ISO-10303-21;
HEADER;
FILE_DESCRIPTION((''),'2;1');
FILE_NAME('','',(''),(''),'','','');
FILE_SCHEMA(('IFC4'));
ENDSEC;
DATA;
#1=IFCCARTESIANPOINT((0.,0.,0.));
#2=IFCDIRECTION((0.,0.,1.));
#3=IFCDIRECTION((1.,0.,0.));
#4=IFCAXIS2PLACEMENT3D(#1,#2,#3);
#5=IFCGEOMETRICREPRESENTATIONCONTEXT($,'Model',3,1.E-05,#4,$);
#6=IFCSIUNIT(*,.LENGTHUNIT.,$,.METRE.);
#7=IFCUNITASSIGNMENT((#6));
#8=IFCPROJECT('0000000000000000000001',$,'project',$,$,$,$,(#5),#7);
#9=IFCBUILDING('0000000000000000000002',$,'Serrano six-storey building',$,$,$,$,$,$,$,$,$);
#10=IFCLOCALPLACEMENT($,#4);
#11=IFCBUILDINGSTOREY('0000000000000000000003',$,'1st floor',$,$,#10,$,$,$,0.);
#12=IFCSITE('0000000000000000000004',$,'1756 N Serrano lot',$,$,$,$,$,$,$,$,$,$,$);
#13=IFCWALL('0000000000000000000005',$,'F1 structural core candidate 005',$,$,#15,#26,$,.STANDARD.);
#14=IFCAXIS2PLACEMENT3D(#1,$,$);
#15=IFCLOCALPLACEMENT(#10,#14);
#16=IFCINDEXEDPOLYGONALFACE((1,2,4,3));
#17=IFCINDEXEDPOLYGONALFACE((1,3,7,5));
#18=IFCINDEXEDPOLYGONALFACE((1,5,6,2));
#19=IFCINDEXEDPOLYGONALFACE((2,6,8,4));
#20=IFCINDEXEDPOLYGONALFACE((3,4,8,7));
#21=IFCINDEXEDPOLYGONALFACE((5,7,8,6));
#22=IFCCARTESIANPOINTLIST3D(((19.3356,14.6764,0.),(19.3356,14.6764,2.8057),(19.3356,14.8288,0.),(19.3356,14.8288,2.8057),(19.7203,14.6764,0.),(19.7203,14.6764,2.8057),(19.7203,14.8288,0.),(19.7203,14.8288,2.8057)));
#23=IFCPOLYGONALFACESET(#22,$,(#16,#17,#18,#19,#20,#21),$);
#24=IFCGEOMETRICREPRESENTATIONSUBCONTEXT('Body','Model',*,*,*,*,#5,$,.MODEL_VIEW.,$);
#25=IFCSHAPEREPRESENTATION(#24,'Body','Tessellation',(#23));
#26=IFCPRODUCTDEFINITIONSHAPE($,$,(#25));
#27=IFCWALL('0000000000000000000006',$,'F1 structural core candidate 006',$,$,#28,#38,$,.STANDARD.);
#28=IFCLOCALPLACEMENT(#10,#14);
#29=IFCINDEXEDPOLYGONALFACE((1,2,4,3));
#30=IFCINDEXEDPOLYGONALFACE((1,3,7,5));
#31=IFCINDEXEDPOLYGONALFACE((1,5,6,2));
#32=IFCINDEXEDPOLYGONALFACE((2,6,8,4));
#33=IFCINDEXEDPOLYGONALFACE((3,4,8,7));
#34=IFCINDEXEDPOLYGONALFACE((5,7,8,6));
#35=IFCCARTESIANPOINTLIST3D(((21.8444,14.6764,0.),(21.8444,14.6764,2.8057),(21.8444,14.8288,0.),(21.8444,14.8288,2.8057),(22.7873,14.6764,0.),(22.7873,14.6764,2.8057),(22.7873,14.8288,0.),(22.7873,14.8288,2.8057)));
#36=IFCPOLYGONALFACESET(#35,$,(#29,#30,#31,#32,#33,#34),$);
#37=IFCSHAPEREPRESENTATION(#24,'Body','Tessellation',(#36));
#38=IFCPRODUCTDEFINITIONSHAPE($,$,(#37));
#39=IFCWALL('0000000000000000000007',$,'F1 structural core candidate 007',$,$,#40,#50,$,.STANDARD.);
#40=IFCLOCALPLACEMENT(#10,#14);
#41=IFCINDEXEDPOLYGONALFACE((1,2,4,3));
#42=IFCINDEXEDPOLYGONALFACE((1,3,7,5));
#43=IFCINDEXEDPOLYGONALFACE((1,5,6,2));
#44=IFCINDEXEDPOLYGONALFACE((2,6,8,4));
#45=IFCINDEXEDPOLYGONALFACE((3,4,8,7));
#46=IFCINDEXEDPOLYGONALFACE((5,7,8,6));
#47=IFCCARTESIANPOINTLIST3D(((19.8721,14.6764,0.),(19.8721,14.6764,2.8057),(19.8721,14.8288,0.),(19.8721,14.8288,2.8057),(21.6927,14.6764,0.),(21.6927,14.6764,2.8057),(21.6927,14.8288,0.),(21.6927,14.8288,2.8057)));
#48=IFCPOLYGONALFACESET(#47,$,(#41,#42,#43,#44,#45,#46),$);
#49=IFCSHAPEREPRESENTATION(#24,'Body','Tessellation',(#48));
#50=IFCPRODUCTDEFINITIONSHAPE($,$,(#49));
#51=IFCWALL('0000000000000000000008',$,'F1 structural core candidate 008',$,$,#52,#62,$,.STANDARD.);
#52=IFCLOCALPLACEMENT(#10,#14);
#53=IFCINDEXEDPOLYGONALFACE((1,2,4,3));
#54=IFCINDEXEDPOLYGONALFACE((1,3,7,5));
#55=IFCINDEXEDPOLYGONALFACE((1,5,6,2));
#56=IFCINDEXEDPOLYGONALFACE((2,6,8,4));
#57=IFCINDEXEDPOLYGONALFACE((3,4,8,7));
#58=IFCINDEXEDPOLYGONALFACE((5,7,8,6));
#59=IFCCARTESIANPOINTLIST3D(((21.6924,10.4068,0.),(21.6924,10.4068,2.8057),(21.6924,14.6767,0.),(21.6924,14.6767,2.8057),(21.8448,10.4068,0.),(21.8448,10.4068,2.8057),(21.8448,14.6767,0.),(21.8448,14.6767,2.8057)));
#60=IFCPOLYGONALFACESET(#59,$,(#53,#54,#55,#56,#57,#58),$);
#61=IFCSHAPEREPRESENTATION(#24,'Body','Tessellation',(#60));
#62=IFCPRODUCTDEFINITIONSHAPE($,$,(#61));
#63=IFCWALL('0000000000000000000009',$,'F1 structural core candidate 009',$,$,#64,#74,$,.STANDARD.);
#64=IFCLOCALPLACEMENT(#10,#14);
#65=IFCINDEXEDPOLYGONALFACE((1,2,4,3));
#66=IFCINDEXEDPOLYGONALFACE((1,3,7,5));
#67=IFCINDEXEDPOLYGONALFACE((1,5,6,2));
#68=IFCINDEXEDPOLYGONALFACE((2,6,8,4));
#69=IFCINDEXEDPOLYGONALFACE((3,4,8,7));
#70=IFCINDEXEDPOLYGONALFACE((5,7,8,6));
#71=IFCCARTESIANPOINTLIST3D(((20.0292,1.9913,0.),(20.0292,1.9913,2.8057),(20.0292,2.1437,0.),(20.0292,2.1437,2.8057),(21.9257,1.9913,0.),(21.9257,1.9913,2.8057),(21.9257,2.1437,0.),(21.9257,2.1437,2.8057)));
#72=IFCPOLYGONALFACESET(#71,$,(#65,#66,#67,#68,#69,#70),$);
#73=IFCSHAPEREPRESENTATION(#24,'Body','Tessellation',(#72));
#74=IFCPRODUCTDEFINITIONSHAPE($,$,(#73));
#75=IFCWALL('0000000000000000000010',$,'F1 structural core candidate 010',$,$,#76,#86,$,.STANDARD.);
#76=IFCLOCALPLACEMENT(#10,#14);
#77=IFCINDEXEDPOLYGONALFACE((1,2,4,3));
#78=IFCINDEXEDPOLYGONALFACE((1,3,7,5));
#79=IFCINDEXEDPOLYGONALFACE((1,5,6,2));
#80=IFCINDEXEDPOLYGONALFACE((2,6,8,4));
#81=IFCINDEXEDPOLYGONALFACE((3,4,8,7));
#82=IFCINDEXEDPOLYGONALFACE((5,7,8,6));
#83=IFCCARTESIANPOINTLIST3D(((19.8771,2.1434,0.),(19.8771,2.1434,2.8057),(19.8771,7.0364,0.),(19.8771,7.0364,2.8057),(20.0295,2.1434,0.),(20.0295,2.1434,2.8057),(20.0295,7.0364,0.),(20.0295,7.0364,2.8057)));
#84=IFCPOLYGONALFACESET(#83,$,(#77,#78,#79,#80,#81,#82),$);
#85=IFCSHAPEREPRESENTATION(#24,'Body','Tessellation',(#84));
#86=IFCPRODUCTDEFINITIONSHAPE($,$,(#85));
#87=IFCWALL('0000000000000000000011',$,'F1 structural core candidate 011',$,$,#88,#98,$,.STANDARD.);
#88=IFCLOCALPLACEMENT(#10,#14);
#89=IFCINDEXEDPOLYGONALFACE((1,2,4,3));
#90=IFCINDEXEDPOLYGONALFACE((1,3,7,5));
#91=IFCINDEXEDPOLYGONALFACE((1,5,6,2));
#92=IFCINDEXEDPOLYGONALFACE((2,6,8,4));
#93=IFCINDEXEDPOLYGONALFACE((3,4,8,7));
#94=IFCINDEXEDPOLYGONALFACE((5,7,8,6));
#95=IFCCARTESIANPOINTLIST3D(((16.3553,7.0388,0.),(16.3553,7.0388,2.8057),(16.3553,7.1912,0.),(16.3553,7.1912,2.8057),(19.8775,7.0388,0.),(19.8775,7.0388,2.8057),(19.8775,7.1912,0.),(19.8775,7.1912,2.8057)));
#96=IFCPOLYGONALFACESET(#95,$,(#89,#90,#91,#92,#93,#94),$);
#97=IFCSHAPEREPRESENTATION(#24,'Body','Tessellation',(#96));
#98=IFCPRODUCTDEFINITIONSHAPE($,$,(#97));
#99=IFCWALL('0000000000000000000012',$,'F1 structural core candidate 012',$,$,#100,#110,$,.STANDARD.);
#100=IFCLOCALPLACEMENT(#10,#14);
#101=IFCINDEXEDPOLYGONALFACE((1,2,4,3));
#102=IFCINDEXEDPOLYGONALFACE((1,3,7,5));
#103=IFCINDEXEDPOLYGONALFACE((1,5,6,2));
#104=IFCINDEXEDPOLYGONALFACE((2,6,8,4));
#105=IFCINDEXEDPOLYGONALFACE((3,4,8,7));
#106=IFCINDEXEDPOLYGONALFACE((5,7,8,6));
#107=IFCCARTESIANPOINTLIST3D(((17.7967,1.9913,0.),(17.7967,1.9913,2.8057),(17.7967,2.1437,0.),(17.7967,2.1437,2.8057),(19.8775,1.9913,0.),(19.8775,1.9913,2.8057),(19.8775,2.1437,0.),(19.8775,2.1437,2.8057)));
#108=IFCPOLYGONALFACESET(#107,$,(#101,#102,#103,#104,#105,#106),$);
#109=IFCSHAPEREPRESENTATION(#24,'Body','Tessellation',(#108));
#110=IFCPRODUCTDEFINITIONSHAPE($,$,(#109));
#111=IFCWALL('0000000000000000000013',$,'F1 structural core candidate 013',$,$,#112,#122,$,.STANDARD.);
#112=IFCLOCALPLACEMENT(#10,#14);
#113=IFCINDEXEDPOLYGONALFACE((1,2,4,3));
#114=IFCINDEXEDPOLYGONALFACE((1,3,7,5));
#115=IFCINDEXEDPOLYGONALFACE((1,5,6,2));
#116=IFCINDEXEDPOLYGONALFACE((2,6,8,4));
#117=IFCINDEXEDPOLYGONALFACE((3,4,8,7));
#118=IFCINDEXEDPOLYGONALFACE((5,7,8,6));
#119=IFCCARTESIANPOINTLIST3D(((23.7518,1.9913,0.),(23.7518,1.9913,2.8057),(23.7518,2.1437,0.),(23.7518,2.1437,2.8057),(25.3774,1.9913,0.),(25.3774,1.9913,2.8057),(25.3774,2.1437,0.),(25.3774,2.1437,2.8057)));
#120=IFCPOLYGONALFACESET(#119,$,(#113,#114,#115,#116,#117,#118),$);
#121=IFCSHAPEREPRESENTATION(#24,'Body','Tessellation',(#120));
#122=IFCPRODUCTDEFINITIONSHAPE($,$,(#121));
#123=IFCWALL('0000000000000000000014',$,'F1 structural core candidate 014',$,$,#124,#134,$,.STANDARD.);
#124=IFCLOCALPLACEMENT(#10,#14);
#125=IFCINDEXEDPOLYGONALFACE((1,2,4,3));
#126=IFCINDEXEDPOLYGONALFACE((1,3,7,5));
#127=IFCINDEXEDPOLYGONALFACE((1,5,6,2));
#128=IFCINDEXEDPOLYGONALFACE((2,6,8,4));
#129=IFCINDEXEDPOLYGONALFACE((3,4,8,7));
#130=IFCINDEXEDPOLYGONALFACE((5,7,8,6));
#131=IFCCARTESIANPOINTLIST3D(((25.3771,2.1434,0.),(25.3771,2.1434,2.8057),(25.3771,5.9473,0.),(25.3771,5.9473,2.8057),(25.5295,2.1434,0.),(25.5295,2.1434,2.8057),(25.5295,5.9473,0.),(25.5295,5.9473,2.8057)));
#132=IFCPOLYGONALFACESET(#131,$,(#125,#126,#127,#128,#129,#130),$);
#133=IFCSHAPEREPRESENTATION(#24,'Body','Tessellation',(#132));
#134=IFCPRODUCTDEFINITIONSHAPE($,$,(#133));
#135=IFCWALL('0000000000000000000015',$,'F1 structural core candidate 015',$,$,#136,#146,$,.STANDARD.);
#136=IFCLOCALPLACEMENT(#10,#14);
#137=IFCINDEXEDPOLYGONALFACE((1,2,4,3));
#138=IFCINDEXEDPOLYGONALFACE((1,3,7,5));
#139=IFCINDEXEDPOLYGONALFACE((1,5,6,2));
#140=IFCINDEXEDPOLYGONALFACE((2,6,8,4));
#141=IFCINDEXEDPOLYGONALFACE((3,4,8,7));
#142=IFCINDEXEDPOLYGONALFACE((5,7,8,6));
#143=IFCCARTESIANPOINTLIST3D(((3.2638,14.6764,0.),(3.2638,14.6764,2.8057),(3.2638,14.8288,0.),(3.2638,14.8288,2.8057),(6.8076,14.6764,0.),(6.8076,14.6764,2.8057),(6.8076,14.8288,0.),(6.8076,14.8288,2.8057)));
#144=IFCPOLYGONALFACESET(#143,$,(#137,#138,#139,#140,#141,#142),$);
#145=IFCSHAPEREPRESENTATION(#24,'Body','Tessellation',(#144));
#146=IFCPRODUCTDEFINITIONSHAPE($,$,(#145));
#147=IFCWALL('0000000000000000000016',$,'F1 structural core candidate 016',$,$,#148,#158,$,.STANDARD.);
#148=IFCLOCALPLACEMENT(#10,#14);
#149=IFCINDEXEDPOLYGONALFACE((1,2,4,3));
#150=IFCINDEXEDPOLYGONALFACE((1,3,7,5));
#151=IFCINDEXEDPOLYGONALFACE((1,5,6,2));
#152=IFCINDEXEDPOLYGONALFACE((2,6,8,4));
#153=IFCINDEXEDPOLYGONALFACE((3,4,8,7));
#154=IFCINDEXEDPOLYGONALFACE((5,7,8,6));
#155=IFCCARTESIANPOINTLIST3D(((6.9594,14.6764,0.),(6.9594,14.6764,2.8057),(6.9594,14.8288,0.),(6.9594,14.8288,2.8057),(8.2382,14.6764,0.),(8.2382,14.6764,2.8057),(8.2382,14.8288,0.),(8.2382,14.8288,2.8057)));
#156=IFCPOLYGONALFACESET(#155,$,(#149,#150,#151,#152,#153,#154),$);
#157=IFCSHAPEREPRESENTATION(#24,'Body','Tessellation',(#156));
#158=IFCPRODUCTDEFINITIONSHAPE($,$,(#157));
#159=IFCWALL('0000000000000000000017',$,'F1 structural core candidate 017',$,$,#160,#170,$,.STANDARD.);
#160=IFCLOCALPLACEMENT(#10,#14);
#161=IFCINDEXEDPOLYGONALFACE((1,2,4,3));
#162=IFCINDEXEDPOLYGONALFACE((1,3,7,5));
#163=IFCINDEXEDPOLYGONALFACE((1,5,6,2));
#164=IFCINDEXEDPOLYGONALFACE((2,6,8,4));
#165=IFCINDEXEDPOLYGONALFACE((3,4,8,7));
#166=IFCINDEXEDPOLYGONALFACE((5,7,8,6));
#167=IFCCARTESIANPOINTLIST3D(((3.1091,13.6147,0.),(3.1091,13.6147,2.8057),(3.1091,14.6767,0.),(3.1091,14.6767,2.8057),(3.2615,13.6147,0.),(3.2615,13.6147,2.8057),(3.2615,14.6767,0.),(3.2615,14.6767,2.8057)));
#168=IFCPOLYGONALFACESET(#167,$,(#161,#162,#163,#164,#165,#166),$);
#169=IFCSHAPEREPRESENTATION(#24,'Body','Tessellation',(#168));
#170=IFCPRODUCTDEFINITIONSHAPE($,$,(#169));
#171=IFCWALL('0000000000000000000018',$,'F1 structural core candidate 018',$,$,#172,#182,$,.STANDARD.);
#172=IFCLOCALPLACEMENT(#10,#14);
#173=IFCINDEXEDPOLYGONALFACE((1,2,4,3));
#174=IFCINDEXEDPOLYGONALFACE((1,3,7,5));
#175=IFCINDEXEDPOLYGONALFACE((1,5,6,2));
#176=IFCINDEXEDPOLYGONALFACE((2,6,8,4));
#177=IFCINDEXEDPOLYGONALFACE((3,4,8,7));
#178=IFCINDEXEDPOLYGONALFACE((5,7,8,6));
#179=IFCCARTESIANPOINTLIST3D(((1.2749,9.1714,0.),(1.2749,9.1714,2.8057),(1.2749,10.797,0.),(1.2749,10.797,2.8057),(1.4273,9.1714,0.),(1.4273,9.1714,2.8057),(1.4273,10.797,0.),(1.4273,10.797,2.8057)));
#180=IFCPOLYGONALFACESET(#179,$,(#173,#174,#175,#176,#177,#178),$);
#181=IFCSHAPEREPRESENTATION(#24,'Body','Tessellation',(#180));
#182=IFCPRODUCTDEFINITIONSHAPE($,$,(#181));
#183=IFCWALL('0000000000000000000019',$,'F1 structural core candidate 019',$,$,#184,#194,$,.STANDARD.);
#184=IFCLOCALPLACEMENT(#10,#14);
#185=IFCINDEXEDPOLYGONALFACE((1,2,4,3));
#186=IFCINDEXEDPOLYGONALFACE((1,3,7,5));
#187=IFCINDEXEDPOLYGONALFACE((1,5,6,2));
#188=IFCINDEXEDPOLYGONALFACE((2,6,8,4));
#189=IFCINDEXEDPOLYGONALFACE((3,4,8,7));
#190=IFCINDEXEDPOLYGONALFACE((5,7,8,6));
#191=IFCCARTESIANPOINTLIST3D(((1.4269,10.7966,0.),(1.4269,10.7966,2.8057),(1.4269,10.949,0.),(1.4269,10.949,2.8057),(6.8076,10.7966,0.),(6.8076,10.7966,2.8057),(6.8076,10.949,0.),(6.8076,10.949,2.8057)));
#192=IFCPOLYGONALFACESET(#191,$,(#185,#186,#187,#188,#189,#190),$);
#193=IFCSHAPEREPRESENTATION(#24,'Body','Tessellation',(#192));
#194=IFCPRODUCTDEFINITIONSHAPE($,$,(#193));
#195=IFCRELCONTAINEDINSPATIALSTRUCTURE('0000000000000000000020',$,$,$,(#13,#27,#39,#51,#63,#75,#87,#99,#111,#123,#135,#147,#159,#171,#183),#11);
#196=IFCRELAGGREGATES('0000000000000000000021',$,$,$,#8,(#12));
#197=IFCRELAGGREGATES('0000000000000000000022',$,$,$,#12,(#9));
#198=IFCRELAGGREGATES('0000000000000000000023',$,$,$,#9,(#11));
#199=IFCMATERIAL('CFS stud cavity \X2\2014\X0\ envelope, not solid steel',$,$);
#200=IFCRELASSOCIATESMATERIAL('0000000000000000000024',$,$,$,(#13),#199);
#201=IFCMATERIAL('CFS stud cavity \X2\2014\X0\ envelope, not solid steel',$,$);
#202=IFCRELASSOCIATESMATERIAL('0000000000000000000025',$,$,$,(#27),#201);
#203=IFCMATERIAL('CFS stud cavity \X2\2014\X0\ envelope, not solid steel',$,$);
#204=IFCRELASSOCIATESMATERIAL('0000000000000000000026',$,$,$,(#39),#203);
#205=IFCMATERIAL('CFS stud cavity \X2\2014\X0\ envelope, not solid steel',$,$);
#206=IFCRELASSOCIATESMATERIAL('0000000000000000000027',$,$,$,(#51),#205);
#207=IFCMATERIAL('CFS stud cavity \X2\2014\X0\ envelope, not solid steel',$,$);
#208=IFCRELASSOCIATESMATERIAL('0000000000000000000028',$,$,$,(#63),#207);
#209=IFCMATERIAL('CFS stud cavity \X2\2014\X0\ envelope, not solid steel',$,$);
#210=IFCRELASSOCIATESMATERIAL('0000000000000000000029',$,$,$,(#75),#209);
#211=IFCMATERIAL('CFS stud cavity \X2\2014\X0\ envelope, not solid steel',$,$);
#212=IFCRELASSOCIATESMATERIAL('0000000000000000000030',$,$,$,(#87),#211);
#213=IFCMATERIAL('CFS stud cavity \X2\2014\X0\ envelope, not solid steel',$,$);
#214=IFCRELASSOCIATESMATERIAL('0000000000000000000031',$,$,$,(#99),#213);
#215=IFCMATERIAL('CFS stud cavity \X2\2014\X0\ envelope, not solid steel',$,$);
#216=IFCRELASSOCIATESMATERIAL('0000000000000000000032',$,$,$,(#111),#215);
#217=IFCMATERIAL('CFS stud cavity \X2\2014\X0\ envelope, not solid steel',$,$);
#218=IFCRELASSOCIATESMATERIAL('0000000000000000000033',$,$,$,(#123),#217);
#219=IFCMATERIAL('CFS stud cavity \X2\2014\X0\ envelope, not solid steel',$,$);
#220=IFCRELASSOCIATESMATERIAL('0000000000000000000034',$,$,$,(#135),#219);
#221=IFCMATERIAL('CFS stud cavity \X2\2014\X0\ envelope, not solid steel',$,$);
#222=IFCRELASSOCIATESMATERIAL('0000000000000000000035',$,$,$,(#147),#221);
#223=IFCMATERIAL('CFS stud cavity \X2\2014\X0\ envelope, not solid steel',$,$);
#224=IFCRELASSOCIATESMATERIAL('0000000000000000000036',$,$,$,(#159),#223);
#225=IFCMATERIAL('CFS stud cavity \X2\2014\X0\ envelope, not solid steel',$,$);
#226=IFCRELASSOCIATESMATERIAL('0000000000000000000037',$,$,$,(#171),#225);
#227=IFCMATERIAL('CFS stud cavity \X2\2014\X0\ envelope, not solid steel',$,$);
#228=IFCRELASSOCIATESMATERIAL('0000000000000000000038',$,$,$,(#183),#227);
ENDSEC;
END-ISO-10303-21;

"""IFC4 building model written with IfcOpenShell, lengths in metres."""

from ifc_helpers import new_model, si_unit, origin, origin_with_axes, place, context, subcontext, project, spatial, polyline, outline, extrude, material, element, save


model = new_model("IFC4")

# Units and contexts
model_context = context("Model", 3, precision=1e-05, world=origin_with_axes())
body_context = subcontext(model_context, "Body", "Model", "MODEL_VIEW")
ifc_project = project(units=[si_unit("LENGTHUNIT", "METRE")], contexts=[model_context])

# Site, building, storey
site = spatial("IfcSite", under=ifc_project, Name="1756 N Serrano lot")
building = spatial("IfcBuilding", under=site, Name="Serrano six-storey building")
storey_placement = place(None, origin_with_axes())
storey = spatial("IfcBuildingStorey", under=building, at=storey_placement, Name="1st floor", Elevation=0.0)

# Walls
ifc_material_1 = material(Name="CFS stud cavity — envelope, not solid steel")
wall_1_placement = place(storey_placement, origin_with_axes())
element("IfcWall", 1, at=wall_1_placement, inside=storey, material=ifc_material_1, Name="F1 structural core candidate 005", PredefinedType="STANDARD", context=body_context, shape_type="SweptSolid", body=[
    extrude(outline(polyline([(19.7203, 14.8288), (19.7203, 14.6764), (19.3356, 14.6764), (19.3356, 14.8288), (19.7203, 14.8288)])), origin(), (0.0, 0.0, 1.0), 2.8057),
])
ifc_material_2 = material(Name="CFS stud cavity — envelope, not solid steel")
wall_2_placement = place(storey_placement, origin_with_axes())
element("IfcWall", 2, at=wall_2_placement, inside=storey, material=ifc_material_2, Name="F1 structural core candidate 006", PredefinedType="STANDARD", context=body_context, shape_type="SweptSolid", body=[
    extrude(outline(polyline([(22.7873, 14.8288), (22.7873, 14.6764), (21.8444, 14.6764), (21.8444, 14.8288), (22.7873, 14.8288)])), origin(), (0.0, 0.0, 1.0), 2.8057),
])
ifc_material_3 = material(Name="CFS stud cavity — envelope, not solid steel")
wall_3_placement = place(storey_placement, origin_with_axes())
element("IfcWall", 3, at=wall_3_placement, inside=storey, material=ifc_material_3, Name="F1 structural core candidate 007", PredefinedType="STANDARD", context=body_context, shape_type="SweptSolid", body=[
    extrude(outline(polyline([(21.6927, 14.8288), (21.6927, 14.6764), (19.8721, 14.6764), (19.8721, 14.8288), (21.6927, 14.8288)])), origin(), (0.0, 0.0, 1.0), 2.8057),
])
ifc_material_4 = material(Name="CFS stud cavity — envelope, not solid steel")
wall_4_placement = place(storey_placement, origin_with_axes())
element("IfcWall", 4, at=wall_4_placement, inside=storey, material=ifc_material_4, Name="F1 structural core candidate 008", PredefinedType="STANDARD", context=body_context, shape_type="SweptSolid", body=[
    extrude(outline(polyline([(21.8448, 10.4068), (21.6924, 10.4068), (21.6924, 14.6767), (21.8448, 14.6767), (21.8448, 10.4068)])), origin(), (0.0, 0.0, 1.0), 2.8057),
])
ifc_material_5 = material(Name="CFS stud cavity — envelope, not solid steel")
wall_5_placement = place(storey_placement, origin_with_axes())
element("IfcWall", 5, at=wall_5_placement, inside=storey, material=ifc_material_5, Name="F1 structural core candidate 009", PredefinedType="STANDARD", context=body_context, shape_type="SweptSolid", body=[
    extrude(outline(polyline([(21.9257, 2.1437), (21.9257, 1.9913), (20.0292, 1.9913), (20.0292, 2.1437), (21.9257, 2.1437)])), origin(), (0.0, 0.0, 1.0), 2.8057),
])
ifc_material_6 = material(Name="CFS stud cavity — envelope, not solid steel")
wall_6_placement = place(storey_placement, origin_with_axes())
element("IfcWall", 6, at=wall_6_placement, inside=storey, material=ifc_material_6, Name="F1 structural core candidate 010", PredefinedType="STANDARD", context=body_context, shape_type="SweptSolid", body=[
    extrude(outline(polyline([(20.0295, 2.1434), (19.8771, 2.1434), (19.8771, 7.0364), (20.0295, 7.0364), (20.0295, 2.1434)])), origin(), (0.0, 0.0, 1.0), 2.8057),
])
ifc_material_7 = material(Name="CFS stud cavity — envelope, not solid steel")
wall_7_placement = place(storey_placement, origin_with_axes())
element("IfcWall", 7, at=wall_7_placement, inside=storey, material=ifc_material_7, Name="F1 structural core candidate 011", PredefinedType="STANDARD", context=body_context, shape_type="SweptSolid", body=[
    extrude(outline(polyline([(19.8775, 7.1912), (19.8775, 7.0388), (16.3553, 7.0388), (16.3553, 7.1912), (19.8775, 7.1912)])), origin(), (0.0, 0.0, 1.0), 2.8057),
])
ifc_material_8 = material(Name="CFS stud cavity — envelope, not solid steel")
wall_8_placement = place(storey_placement, origin_with_axes())
element("IfcWall", 8, at=wall_8_placement, inside=storey, material=ifc_material_8, Name="F1 structural core candidate 012", PredefinedType="STANDARD", context=body_context, shape_type="SweptSolid", body=[
    extrude(outline(polyline([(19.8775, 2.1437), (19.8775, 1.9913), (17.7967, 1.9913), (17.7967, 2.1437), (19.8775, 2.1437)])), origin(), (0.0, 0.0, 1.0), 2.8057),
])
ifc_material_9 = material(Name="CFS stud cavity — envelope, not solid steel")
wall_9_placement = place(storey_placement, origin_with_axes())
element("IfcWall", 9, at=wall_9_placement, inside=storey, material=ifc_material_9, Name="F1 structural core candidate 013", PredefinedType="STANDARD", context=body_context, shape_type="SweptSolid", body=[
    extrude(outline(polyline([(25.3774, 2.1437), (25.3774, 1.9913), (23.7518, 1.9913), (23.7518, 2.1437), (25.3774, 2.1437)])), origin(), (0.0, 0.0, 1.0), 2.8057),
])
ifc_material_10 = material(Name="CFS stud cavity — envelope, not solid steel")
wall_10_placement = place(storey_placement, origin_with_axes())
element("IfcWall", 10, at=wall_10_placement, inside=storey, material=ifc_material_10, Name="F1 structural core candidate 014", PredefinedType="STANDARD", context=body_context, shape_type="SweptSolid", body=[
    extrude(outline(polyline([(25.5295, 2.1434), (25.3771, 2.1434), (25.3771, 5.9473), (25.5295, 5.9473), (25.5295, 2.1434)])), origin(), (0.0, 0.0, 1.0), 2.8057),
])
ifc_material_11 = material(Name="CFS stud cavity — envelope, not solid steel")
wall_11_placement = place(storey_placement, origin_with_axes())
element("IfcWall", 11, at=wall_11_placement, inside=storey, material=ifc_material_11, Name="F1 structural core candidate 015", PredefinedType="STANDARD", context=body_context, shape_type="SweptSolid", body=[
    extrude(outline(polyline([(6.8076, 14.8288), (6.8076, 14.6764), (3.2638, 14.6764), (3.2638, 14.8288), (6.8076, 14.8288)])), origin(), (0.0, 0.0, 1.0), 2.8057),
])
ifc_material_12 = material(Name="CFS stud cavity — envelope, not solid steel")
wall_12_placement = place(storey_placement, origin_with_axes())
element("IfcWall", 12, at=wall_12_placement, inside=storey, material=ifc_material_12, Name="F1 structural core candidate 016", PredefinedType="STANDARD", context=body_context, shape_type="SweptSolid", body=[
    extrude(outline(polyline([(8.2382, 14.8288), (8.2382, 14.6764), (6.9594, 14.6764), (6.9594, 14.8288), (8.2382, 14.8288)])), origin(), (0.0, 0.0, 1.0), 2.8057),
])
ifc_material_13 = material(Name="CFS stud cavity — envelope, not solid steel")
wall_13_placement = place(storey_placement, origin_with_axes())
element("IfcWall", 13, at=wall_13_placement, inside=storey, material=ifc_material_13, Name="F1 structural core candidate 017", PredefinedType="STANDARD", context=body_context, shape_type="SweptSolid", body=[
    extrude(outline(polyline([(3.2615, 13.6147), (3.1091, 13.6147), (3.1091, 14.6767), (3.2615, 14.6767), (3.2615, 13.6147)])), origin(), (0.0, 0.0, 1.0), 2.8057),
])
ifc_material_14 = material(Name="CFS stud cavity — envelope, not solid steel")
wall_14_placement = place(storey_placement, origin_with_axes())
element("IfcWall", 14, at=wall_14_placement, inside=storey, material=ifc_material_14, Name="F1 structural core candidate 018", PredefinedType="STANDARD", context=body_context, shape_type="SweptSolid", body=[
    extrude(outline(polyline([(1.4273, 9.1714), (1.2749, 9.1714), (1.2749, 10.797), (1.4273, 10.797), (1.4273, 9.1714)])), origin(), (0.0, 0.0, 1.0), 2.8057),
])
ifc_material_15 = material(Name="CFS stud cavity — envelope, not solid steel")
wall_15_placement = place(storey_placement, origin_with_axes())
element("IfcWall", 15, at=wall_15_placement, inside=storey, material=ifc_material_15, Name="F1 structural core candidate 019", PredefinedType="STANDARD", context=body_context, shape_type="SweptSolid", body=[
    extrude(outline(polyline([(6.8076, 10.949), (6.8076, 10.7966), (1.4269, 10.7966), (1.4269, 10.949), (6.8076, 10.949)])), origin(), (0.0, 0.0, 1.0), 2.8057),
])

save(model, "model.ifc")
